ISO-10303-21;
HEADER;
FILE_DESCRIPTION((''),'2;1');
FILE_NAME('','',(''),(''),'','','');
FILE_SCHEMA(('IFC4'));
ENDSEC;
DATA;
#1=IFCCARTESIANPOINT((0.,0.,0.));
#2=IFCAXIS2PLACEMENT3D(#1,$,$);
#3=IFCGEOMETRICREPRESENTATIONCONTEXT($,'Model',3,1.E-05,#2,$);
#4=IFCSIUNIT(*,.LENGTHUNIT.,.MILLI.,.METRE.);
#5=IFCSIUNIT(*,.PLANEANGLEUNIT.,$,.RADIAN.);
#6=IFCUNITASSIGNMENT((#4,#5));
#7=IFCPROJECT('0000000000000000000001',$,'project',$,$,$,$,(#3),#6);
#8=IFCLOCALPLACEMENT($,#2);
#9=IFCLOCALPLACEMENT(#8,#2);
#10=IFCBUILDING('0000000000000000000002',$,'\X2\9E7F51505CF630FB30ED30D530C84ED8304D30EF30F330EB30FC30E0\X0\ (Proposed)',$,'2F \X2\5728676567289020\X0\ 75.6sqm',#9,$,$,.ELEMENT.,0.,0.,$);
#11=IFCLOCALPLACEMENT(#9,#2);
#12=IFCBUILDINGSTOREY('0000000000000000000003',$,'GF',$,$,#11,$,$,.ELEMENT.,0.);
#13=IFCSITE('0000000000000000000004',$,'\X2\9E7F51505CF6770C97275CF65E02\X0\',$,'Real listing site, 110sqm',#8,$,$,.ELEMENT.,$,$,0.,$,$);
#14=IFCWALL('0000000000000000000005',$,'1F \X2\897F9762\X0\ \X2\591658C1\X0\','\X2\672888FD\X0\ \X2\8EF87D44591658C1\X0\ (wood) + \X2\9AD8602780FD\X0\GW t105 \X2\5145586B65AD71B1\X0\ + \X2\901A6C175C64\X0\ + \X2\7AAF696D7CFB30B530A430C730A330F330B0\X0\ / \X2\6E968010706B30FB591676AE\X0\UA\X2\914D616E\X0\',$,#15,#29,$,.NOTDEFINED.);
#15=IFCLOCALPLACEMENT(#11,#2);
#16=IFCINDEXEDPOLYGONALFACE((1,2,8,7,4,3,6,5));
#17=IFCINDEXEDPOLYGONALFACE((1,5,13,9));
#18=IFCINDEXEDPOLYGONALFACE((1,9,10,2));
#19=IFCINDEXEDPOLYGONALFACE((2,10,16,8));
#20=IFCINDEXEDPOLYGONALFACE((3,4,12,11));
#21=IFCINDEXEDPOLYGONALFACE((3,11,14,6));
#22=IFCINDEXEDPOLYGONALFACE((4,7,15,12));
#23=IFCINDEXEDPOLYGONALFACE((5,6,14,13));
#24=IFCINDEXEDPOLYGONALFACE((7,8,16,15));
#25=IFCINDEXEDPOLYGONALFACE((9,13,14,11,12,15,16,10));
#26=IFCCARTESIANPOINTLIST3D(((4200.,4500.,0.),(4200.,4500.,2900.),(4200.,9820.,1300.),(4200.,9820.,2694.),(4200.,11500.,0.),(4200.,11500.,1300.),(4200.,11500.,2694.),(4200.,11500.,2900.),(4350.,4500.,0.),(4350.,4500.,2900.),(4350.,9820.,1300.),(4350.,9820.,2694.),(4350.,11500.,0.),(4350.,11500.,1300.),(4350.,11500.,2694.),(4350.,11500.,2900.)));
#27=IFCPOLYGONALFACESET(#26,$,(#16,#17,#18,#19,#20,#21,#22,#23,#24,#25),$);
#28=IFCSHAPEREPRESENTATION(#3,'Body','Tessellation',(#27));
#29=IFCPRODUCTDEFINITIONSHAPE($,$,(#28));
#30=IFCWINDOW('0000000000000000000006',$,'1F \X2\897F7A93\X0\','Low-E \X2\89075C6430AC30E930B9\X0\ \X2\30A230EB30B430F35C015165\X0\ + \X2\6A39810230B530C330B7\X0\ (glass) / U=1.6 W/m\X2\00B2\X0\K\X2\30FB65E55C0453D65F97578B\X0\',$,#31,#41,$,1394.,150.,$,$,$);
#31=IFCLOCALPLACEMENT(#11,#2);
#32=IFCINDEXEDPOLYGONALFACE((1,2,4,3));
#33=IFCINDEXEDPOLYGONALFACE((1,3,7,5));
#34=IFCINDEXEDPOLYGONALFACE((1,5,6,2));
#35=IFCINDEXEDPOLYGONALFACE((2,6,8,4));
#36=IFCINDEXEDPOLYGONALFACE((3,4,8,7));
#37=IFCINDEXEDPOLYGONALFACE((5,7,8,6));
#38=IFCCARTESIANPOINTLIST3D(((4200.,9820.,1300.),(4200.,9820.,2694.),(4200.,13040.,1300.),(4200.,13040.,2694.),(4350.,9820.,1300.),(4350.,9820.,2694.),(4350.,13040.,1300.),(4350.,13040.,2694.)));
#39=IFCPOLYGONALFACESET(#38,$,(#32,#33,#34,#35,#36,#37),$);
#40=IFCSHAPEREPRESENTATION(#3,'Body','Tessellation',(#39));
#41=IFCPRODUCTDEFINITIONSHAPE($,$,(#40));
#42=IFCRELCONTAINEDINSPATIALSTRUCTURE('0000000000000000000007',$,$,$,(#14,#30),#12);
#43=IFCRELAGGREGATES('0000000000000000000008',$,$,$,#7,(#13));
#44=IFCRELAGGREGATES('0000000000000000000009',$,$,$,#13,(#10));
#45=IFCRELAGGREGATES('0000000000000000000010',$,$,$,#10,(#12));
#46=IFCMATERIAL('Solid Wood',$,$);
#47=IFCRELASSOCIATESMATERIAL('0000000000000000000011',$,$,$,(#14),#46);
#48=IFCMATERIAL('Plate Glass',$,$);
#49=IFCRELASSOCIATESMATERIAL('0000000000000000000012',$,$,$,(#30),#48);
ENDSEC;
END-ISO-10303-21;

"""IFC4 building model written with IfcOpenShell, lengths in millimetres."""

from ifc_helpers import new_model, si_unit, frame, frame_2d, origin, place, context, project, spatial, rectangle, extrude, material, element, fill, save


model = new_model("IFC4")

# Units and contexts
model_context = context("Model", 3, precision=1e-05, world=origin())
ifc_project = project(units=[si_unit("LENGTHUNIT", "METRE", prefix="MILLI"), si_unit("PLANEANGLEUNIT", "RADIAN")], contexts=[model_context])

# Site, building, storey
site_placement = place(None, origin())
site = spatial("IfcSite", under=ifc_project, at=site_placement, Name="鹿児島県霧島市", ObjectType="Real listing site, 110sqm", CompositionType="ELEMENT", RefElevation=0.0)
building_placement = place(site_placement, origin())
building = spatial("IfcBuilding", under=site, at=building_placement, Name="鹿児島・ロフト付きワンルーム (Proposed)", ObjectType="2F 在来木造 75.6sqm", CompositionType="ELEMENT", ElevationOfRefHeight=0.0, ElevationOfTerrain=0.0)
storey_placement = place(building_placement, origin())
storey = spatial("IfcBuildingStorey", under=building, at=storey_placement, Name="GF", CompositionType="ELEMENT", Elevation=0.0)

# Shared definitions
ifc_material_1 = material(Name="Solid Wood")

# Shared definitions
ifc_material_2 = material(Name="Plate Glass")

# Wall, opening, window
wall_1_placement = place(storey_placement, frame((2100.0, 2250.0, 0.0)))
wall_1 = element("IfcWall", 1, at=wall_1_placement, inside=storey, material=ifc_material_1, Name="1F 西面 外壁", Description="木製 軸組外壁 (wood) + 高性能GW t105 充填断熱 + 通気層 + 窯業系サイディング / 準耐火・外皮UA配慮", PredefinedType="NOTDEFINED", context=model_context, shape_type="SweptSolid", body=[
    extrude(rectangle(XDim=150.0, YDim=7000.0, at=frame_2d((75.0, 3500.0))), frame((2100.0, 2250.0, 0.0)), (0.0, 0.0, 1.0), 2900.0),
])
opening_1_placement = place(storey_placement, frame((2100.0, 4910.0, 650.0)))
opening_1 = element("IfcOpeningElement", 2, at=opening_1_placement, cuts=wall_1, PredefinedType="NOTDEFINED", context=model_context, shape_type="SweptSolid", body=[
    extrude(rectangle(XDim=150.0, YDim=3220.0, at=frame_2d((75.0, 1610.0))), frame((2100.0, 4910.0, 650.0)), (0.0, 0.0, 1.0), 1394.0),
])
window_1_placement = place(storey_placement, frame((2100.0, 4910.0, 650.0)))
window_1 = element("IfcWindow", 3, at=window_1_placement, inside=storey, material=ifc_material_2, Name="1F 西窓", Description="Low-E 複層ガラス アルゴン封入 + 樹脂サッシ (glass) / U=1.6 W/m²K・日射取得型", OverallHeight=1394.0, OverallWidth=150.0, context=model_context, shape_type="SweptSolid", body=[
    extrude(rectangle(XDim=150.0, YDim=3220.0, at=frame_2d((75.0, 1610.0))), frame((2100.0, 4910.0, 650.0)), (0.0, 0.0, 1.0), 1394.0),
])
fill(opening_1, window_1)

save(model, "model.ifc")
